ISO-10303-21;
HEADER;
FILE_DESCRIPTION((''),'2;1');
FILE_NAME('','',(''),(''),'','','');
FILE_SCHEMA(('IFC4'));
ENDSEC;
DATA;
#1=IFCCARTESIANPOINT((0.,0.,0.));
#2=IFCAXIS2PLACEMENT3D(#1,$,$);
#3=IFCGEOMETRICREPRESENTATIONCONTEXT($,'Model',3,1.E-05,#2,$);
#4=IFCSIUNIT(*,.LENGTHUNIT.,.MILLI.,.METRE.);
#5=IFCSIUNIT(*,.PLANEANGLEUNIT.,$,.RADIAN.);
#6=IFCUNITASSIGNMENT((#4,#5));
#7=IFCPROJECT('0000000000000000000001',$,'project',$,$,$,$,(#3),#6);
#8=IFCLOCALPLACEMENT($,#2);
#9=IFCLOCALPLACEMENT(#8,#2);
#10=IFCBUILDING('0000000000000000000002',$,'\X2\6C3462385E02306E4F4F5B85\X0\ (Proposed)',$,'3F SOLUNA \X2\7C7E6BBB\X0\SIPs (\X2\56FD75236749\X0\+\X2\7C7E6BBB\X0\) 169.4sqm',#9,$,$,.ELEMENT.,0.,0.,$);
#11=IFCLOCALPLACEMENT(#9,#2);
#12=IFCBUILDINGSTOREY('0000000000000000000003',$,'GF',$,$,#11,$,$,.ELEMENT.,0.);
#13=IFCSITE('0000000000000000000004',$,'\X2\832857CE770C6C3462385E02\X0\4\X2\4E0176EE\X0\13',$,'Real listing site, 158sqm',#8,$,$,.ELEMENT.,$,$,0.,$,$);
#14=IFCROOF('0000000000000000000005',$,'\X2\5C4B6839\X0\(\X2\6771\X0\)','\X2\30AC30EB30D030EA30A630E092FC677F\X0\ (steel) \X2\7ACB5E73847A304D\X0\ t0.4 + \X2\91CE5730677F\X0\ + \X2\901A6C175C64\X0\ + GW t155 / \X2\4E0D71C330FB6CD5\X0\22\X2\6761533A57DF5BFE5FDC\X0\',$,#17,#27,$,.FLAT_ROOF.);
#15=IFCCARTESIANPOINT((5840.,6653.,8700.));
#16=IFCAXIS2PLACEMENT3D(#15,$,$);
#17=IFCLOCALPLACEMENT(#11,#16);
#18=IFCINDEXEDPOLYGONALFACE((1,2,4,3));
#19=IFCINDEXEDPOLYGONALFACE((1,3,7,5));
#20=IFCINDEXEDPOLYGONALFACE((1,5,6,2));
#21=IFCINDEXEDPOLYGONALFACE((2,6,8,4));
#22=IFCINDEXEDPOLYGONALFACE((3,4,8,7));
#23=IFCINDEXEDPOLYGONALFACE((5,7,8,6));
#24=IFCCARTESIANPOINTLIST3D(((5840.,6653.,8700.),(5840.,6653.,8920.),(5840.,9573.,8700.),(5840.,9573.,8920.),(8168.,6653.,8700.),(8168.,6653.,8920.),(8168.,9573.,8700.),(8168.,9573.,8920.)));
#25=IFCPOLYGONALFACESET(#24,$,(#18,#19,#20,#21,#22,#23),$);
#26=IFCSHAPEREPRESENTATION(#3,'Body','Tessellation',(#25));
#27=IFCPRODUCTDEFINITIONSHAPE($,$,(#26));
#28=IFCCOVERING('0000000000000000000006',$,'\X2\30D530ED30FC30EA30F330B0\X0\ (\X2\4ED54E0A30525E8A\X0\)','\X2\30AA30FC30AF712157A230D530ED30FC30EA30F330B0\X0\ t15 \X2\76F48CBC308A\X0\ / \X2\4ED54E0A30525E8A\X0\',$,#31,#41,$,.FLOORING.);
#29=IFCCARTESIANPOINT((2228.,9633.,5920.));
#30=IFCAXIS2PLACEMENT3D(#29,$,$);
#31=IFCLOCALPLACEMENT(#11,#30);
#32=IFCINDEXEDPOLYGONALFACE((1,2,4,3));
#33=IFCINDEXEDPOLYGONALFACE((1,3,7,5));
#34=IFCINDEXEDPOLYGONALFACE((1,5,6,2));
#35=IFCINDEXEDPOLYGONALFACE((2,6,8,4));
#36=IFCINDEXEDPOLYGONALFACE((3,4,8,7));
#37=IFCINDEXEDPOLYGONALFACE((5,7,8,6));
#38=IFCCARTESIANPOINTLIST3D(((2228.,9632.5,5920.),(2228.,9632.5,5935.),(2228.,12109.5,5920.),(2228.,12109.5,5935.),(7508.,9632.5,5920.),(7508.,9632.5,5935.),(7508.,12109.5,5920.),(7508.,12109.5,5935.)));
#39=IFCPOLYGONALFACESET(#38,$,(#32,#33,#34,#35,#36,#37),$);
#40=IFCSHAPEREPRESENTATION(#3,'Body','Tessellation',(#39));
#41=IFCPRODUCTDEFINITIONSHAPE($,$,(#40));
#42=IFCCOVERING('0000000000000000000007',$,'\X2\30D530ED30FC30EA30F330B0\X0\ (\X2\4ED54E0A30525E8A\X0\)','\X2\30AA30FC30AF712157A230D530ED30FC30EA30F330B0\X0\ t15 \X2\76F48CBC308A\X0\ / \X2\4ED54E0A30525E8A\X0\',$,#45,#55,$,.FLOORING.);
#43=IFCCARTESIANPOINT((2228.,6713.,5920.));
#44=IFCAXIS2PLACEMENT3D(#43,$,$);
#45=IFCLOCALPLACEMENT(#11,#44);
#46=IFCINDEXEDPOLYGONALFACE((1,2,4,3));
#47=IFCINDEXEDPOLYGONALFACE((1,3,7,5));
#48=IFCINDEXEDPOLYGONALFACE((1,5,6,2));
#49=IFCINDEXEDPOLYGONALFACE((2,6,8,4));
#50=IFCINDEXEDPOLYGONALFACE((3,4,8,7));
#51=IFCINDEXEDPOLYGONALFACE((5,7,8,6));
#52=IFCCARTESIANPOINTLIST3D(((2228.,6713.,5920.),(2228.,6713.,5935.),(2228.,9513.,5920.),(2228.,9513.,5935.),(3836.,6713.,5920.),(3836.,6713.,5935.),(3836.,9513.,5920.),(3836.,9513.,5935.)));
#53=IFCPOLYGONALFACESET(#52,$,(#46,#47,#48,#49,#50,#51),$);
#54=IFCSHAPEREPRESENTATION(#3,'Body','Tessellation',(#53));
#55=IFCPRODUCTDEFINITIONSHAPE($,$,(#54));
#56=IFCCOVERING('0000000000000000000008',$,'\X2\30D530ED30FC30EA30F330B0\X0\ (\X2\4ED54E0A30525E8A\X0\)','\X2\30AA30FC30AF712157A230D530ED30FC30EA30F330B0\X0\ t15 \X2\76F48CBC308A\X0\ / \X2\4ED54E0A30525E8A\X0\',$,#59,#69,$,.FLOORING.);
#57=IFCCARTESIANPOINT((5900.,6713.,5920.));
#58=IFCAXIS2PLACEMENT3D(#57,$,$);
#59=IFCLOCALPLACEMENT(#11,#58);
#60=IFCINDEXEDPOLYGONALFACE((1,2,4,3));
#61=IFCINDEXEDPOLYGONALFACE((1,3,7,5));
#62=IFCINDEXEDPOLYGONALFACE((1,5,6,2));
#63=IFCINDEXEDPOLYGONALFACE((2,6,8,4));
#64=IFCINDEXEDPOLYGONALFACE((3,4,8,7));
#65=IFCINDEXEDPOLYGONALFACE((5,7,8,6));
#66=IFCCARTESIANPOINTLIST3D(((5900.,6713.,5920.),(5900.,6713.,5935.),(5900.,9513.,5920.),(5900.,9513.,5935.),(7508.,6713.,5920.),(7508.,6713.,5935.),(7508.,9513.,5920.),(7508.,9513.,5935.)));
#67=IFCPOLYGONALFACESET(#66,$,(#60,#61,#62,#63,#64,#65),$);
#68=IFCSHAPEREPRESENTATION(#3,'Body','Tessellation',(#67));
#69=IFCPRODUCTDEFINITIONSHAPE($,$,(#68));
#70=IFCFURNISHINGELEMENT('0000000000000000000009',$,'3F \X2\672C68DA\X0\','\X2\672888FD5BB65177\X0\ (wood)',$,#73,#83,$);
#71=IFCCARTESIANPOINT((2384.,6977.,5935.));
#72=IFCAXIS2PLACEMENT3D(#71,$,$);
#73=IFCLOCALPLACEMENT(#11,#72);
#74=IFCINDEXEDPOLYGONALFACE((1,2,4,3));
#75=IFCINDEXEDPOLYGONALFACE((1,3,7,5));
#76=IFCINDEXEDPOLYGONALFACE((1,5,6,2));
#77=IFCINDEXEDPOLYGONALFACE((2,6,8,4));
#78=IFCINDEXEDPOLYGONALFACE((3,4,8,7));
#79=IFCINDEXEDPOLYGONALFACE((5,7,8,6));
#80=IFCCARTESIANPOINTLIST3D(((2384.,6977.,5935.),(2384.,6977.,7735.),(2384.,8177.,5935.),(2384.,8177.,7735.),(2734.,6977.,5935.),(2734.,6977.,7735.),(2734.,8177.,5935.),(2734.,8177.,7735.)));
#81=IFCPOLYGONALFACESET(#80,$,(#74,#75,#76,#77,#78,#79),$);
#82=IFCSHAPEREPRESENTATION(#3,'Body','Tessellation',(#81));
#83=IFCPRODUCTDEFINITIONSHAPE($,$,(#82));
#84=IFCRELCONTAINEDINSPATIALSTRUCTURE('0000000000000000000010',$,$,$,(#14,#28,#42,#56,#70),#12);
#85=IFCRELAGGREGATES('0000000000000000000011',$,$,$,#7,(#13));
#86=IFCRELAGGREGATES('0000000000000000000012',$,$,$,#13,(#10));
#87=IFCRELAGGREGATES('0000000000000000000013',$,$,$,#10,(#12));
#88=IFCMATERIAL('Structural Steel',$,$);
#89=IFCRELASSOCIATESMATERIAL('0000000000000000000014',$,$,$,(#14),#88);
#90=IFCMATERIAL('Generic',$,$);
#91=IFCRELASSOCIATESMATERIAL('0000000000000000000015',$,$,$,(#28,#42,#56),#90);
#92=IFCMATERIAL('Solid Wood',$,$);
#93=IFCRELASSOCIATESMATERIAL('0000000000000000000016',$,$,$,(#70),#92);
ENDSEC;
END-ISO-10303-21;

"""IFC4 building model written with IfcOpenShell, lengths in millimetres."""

from ifc_helpers import new_model, si_unit, frame, frame_2d, origin, place, context, project, spatial, rectangle, extrude, material, element, save


model = new_model("IFC4")

# Units and contexts
model_context = context("Model", 3, precision=1e-05, world=origin())
ifc_project = project(units=[si_unit("LENGTHUNIT", "METRE", prefix="MILLI"), si_unit("PLANEANGLEUNIT", "RADIAN")], contexts=[model_context])

# Site, building, storey
site_placement = place(None, origin())
site = spatial("IfcSite", under=ifc_project, at=site_placement, Name="茨城県水戸市4丁目13", ObjectType="Real listing site, 158sqm", CompositionType="ELEMENT", RefElevation=0.0)
building_placement = place(site_placement, origin())
building = spatial("IfcBuilding", under=site, at=building_placement, Name="水戸市の住宅 (Proposed)", ObjectType="3F SOLUNA 籾殻SIPs (国産杉+籾殻) 169.4sqm", CompositionType="ELEMENT", ElevationOfRefHeight=0.0, ElevationOfTerrain=0.0)
storey_placement = place(building_placement, origin())
storey = spatial("IfcBuildingStorey", under=building, at=storey_placement, Name="GF", CompositionType="ELEMENT", Elevation=0.0)

# Shared definitions
ifc_material_1 = material(Name="Solid Wood")

# Shared definitions
ifc_material_2 = material(Name="Generic")

# Roof
ifc_material_3 = material(Name="Structural Steel")
roof_1_placement = place(storey_placement, frame((5840.0, 6653.0, 8700.0)))
element("IfcRoof", 1, at=roof_1_placement, inside=storey, material=ifc_material_3, Name="屋根(東)", Description="ガルバリウム鋼板 (steel) 立平葺き t0.4 + 野地板 + 通気層 + GW t155 / 不燃・法22条区域対応", PredefinedType="FLAT_ROOF", context=model_context, shape_type="SweptSolid", body=[
    extrude(rectangle(XDim=2328.0, YDim=2920.0, at=frame_2d((1164.0, 1460.0))), frame((5840.0, 6653.0, 8700.0)), (0.0, 0.0, 1.0), 220.0),
])

# Coverings
covering_1_placement = place(storey_placement, frame((2228.0, 9633.0, 5920.0)))
element("IfcCovering", 2, at=covering_1_placement, inside=storey, material=ifc_material_2, Name="フローリング (仕上げ床)", Description="オーク無垢フローリング t15 直貼り / 仕上げ床", PredefinedType="FLOORING", context=model_context, shape_type="SweptSolid", body=[
    extrude(rectangle(XDim=5280.0, YDim=2477.0, at=frame_2d((2640.0, 1238.0))), frame((2228.0, 9633.0, 5920.0)), (0.0, 0.0, 1.0), 15.0),
])
covering_2_placement = place(storey_placement, frame((2228.0, 6713.0, 5920.0)))
element("IfcCovering", 3, at=covering_2_placement, inside=storey, material=ifc_material_2, Name="フローリング (仕上げ床)", Description="オーク無垢フローリング t15 直貼り / 仕上げ床", PredefinedType="FLOORING", context=model_context, shape_type="SweptSolid", body=[
    extrude(rectangle(XDim=1608.0, YDim=2800.0, at=frame_2d((804.0, 1400.0))), frame((2228.0, 6713.0, 5920.0)), (0.0, 0.0, 1.0), 15.0),
])
covering_3_placement = place(storey_placement, frame((5900.0, 6713.0, 5920.0)))
element("IfcCovering", 4, at=covering_3_placement, inside=storey, material=ifc_material_2, Name="フローリング (仕上げ床)", Description="オーク無垢フローリング t15 直貼り / 仕上げ床", PredefinedType="FLOORING", context=model_context, shape_type="SweptSolid", body=[
    extrude(rectangle(XDim=1608.0, YDim=2800.0, at=frame_2d((804.0, 1400.0))), frame((5900.0, 6713.0, 5920.0)), (0.0, 0.0, 1.0), 15.0),
])

# Furnishing element
furnishing_placement = place(storey_placement, frame((2384.0, 6977.0, 5935.0)))
element("IfcFurnishingElement", 5, at=furnishing_placement, inside=storey, material=ifc_material_1, Name="3F 本棚", Description="木製家具 (wood)", context=model_context, shape_type="SweptSolid", body=[
    extrude(rectangle(XDim=350.0, YDim=1200.0, at=frame_2d((175.0, 600.0))), frame((2384.0, 6977.0, 5935.0)), (0.0, 0.0, 1.0), 1800.0),
])

save(model, "model.ifc")
